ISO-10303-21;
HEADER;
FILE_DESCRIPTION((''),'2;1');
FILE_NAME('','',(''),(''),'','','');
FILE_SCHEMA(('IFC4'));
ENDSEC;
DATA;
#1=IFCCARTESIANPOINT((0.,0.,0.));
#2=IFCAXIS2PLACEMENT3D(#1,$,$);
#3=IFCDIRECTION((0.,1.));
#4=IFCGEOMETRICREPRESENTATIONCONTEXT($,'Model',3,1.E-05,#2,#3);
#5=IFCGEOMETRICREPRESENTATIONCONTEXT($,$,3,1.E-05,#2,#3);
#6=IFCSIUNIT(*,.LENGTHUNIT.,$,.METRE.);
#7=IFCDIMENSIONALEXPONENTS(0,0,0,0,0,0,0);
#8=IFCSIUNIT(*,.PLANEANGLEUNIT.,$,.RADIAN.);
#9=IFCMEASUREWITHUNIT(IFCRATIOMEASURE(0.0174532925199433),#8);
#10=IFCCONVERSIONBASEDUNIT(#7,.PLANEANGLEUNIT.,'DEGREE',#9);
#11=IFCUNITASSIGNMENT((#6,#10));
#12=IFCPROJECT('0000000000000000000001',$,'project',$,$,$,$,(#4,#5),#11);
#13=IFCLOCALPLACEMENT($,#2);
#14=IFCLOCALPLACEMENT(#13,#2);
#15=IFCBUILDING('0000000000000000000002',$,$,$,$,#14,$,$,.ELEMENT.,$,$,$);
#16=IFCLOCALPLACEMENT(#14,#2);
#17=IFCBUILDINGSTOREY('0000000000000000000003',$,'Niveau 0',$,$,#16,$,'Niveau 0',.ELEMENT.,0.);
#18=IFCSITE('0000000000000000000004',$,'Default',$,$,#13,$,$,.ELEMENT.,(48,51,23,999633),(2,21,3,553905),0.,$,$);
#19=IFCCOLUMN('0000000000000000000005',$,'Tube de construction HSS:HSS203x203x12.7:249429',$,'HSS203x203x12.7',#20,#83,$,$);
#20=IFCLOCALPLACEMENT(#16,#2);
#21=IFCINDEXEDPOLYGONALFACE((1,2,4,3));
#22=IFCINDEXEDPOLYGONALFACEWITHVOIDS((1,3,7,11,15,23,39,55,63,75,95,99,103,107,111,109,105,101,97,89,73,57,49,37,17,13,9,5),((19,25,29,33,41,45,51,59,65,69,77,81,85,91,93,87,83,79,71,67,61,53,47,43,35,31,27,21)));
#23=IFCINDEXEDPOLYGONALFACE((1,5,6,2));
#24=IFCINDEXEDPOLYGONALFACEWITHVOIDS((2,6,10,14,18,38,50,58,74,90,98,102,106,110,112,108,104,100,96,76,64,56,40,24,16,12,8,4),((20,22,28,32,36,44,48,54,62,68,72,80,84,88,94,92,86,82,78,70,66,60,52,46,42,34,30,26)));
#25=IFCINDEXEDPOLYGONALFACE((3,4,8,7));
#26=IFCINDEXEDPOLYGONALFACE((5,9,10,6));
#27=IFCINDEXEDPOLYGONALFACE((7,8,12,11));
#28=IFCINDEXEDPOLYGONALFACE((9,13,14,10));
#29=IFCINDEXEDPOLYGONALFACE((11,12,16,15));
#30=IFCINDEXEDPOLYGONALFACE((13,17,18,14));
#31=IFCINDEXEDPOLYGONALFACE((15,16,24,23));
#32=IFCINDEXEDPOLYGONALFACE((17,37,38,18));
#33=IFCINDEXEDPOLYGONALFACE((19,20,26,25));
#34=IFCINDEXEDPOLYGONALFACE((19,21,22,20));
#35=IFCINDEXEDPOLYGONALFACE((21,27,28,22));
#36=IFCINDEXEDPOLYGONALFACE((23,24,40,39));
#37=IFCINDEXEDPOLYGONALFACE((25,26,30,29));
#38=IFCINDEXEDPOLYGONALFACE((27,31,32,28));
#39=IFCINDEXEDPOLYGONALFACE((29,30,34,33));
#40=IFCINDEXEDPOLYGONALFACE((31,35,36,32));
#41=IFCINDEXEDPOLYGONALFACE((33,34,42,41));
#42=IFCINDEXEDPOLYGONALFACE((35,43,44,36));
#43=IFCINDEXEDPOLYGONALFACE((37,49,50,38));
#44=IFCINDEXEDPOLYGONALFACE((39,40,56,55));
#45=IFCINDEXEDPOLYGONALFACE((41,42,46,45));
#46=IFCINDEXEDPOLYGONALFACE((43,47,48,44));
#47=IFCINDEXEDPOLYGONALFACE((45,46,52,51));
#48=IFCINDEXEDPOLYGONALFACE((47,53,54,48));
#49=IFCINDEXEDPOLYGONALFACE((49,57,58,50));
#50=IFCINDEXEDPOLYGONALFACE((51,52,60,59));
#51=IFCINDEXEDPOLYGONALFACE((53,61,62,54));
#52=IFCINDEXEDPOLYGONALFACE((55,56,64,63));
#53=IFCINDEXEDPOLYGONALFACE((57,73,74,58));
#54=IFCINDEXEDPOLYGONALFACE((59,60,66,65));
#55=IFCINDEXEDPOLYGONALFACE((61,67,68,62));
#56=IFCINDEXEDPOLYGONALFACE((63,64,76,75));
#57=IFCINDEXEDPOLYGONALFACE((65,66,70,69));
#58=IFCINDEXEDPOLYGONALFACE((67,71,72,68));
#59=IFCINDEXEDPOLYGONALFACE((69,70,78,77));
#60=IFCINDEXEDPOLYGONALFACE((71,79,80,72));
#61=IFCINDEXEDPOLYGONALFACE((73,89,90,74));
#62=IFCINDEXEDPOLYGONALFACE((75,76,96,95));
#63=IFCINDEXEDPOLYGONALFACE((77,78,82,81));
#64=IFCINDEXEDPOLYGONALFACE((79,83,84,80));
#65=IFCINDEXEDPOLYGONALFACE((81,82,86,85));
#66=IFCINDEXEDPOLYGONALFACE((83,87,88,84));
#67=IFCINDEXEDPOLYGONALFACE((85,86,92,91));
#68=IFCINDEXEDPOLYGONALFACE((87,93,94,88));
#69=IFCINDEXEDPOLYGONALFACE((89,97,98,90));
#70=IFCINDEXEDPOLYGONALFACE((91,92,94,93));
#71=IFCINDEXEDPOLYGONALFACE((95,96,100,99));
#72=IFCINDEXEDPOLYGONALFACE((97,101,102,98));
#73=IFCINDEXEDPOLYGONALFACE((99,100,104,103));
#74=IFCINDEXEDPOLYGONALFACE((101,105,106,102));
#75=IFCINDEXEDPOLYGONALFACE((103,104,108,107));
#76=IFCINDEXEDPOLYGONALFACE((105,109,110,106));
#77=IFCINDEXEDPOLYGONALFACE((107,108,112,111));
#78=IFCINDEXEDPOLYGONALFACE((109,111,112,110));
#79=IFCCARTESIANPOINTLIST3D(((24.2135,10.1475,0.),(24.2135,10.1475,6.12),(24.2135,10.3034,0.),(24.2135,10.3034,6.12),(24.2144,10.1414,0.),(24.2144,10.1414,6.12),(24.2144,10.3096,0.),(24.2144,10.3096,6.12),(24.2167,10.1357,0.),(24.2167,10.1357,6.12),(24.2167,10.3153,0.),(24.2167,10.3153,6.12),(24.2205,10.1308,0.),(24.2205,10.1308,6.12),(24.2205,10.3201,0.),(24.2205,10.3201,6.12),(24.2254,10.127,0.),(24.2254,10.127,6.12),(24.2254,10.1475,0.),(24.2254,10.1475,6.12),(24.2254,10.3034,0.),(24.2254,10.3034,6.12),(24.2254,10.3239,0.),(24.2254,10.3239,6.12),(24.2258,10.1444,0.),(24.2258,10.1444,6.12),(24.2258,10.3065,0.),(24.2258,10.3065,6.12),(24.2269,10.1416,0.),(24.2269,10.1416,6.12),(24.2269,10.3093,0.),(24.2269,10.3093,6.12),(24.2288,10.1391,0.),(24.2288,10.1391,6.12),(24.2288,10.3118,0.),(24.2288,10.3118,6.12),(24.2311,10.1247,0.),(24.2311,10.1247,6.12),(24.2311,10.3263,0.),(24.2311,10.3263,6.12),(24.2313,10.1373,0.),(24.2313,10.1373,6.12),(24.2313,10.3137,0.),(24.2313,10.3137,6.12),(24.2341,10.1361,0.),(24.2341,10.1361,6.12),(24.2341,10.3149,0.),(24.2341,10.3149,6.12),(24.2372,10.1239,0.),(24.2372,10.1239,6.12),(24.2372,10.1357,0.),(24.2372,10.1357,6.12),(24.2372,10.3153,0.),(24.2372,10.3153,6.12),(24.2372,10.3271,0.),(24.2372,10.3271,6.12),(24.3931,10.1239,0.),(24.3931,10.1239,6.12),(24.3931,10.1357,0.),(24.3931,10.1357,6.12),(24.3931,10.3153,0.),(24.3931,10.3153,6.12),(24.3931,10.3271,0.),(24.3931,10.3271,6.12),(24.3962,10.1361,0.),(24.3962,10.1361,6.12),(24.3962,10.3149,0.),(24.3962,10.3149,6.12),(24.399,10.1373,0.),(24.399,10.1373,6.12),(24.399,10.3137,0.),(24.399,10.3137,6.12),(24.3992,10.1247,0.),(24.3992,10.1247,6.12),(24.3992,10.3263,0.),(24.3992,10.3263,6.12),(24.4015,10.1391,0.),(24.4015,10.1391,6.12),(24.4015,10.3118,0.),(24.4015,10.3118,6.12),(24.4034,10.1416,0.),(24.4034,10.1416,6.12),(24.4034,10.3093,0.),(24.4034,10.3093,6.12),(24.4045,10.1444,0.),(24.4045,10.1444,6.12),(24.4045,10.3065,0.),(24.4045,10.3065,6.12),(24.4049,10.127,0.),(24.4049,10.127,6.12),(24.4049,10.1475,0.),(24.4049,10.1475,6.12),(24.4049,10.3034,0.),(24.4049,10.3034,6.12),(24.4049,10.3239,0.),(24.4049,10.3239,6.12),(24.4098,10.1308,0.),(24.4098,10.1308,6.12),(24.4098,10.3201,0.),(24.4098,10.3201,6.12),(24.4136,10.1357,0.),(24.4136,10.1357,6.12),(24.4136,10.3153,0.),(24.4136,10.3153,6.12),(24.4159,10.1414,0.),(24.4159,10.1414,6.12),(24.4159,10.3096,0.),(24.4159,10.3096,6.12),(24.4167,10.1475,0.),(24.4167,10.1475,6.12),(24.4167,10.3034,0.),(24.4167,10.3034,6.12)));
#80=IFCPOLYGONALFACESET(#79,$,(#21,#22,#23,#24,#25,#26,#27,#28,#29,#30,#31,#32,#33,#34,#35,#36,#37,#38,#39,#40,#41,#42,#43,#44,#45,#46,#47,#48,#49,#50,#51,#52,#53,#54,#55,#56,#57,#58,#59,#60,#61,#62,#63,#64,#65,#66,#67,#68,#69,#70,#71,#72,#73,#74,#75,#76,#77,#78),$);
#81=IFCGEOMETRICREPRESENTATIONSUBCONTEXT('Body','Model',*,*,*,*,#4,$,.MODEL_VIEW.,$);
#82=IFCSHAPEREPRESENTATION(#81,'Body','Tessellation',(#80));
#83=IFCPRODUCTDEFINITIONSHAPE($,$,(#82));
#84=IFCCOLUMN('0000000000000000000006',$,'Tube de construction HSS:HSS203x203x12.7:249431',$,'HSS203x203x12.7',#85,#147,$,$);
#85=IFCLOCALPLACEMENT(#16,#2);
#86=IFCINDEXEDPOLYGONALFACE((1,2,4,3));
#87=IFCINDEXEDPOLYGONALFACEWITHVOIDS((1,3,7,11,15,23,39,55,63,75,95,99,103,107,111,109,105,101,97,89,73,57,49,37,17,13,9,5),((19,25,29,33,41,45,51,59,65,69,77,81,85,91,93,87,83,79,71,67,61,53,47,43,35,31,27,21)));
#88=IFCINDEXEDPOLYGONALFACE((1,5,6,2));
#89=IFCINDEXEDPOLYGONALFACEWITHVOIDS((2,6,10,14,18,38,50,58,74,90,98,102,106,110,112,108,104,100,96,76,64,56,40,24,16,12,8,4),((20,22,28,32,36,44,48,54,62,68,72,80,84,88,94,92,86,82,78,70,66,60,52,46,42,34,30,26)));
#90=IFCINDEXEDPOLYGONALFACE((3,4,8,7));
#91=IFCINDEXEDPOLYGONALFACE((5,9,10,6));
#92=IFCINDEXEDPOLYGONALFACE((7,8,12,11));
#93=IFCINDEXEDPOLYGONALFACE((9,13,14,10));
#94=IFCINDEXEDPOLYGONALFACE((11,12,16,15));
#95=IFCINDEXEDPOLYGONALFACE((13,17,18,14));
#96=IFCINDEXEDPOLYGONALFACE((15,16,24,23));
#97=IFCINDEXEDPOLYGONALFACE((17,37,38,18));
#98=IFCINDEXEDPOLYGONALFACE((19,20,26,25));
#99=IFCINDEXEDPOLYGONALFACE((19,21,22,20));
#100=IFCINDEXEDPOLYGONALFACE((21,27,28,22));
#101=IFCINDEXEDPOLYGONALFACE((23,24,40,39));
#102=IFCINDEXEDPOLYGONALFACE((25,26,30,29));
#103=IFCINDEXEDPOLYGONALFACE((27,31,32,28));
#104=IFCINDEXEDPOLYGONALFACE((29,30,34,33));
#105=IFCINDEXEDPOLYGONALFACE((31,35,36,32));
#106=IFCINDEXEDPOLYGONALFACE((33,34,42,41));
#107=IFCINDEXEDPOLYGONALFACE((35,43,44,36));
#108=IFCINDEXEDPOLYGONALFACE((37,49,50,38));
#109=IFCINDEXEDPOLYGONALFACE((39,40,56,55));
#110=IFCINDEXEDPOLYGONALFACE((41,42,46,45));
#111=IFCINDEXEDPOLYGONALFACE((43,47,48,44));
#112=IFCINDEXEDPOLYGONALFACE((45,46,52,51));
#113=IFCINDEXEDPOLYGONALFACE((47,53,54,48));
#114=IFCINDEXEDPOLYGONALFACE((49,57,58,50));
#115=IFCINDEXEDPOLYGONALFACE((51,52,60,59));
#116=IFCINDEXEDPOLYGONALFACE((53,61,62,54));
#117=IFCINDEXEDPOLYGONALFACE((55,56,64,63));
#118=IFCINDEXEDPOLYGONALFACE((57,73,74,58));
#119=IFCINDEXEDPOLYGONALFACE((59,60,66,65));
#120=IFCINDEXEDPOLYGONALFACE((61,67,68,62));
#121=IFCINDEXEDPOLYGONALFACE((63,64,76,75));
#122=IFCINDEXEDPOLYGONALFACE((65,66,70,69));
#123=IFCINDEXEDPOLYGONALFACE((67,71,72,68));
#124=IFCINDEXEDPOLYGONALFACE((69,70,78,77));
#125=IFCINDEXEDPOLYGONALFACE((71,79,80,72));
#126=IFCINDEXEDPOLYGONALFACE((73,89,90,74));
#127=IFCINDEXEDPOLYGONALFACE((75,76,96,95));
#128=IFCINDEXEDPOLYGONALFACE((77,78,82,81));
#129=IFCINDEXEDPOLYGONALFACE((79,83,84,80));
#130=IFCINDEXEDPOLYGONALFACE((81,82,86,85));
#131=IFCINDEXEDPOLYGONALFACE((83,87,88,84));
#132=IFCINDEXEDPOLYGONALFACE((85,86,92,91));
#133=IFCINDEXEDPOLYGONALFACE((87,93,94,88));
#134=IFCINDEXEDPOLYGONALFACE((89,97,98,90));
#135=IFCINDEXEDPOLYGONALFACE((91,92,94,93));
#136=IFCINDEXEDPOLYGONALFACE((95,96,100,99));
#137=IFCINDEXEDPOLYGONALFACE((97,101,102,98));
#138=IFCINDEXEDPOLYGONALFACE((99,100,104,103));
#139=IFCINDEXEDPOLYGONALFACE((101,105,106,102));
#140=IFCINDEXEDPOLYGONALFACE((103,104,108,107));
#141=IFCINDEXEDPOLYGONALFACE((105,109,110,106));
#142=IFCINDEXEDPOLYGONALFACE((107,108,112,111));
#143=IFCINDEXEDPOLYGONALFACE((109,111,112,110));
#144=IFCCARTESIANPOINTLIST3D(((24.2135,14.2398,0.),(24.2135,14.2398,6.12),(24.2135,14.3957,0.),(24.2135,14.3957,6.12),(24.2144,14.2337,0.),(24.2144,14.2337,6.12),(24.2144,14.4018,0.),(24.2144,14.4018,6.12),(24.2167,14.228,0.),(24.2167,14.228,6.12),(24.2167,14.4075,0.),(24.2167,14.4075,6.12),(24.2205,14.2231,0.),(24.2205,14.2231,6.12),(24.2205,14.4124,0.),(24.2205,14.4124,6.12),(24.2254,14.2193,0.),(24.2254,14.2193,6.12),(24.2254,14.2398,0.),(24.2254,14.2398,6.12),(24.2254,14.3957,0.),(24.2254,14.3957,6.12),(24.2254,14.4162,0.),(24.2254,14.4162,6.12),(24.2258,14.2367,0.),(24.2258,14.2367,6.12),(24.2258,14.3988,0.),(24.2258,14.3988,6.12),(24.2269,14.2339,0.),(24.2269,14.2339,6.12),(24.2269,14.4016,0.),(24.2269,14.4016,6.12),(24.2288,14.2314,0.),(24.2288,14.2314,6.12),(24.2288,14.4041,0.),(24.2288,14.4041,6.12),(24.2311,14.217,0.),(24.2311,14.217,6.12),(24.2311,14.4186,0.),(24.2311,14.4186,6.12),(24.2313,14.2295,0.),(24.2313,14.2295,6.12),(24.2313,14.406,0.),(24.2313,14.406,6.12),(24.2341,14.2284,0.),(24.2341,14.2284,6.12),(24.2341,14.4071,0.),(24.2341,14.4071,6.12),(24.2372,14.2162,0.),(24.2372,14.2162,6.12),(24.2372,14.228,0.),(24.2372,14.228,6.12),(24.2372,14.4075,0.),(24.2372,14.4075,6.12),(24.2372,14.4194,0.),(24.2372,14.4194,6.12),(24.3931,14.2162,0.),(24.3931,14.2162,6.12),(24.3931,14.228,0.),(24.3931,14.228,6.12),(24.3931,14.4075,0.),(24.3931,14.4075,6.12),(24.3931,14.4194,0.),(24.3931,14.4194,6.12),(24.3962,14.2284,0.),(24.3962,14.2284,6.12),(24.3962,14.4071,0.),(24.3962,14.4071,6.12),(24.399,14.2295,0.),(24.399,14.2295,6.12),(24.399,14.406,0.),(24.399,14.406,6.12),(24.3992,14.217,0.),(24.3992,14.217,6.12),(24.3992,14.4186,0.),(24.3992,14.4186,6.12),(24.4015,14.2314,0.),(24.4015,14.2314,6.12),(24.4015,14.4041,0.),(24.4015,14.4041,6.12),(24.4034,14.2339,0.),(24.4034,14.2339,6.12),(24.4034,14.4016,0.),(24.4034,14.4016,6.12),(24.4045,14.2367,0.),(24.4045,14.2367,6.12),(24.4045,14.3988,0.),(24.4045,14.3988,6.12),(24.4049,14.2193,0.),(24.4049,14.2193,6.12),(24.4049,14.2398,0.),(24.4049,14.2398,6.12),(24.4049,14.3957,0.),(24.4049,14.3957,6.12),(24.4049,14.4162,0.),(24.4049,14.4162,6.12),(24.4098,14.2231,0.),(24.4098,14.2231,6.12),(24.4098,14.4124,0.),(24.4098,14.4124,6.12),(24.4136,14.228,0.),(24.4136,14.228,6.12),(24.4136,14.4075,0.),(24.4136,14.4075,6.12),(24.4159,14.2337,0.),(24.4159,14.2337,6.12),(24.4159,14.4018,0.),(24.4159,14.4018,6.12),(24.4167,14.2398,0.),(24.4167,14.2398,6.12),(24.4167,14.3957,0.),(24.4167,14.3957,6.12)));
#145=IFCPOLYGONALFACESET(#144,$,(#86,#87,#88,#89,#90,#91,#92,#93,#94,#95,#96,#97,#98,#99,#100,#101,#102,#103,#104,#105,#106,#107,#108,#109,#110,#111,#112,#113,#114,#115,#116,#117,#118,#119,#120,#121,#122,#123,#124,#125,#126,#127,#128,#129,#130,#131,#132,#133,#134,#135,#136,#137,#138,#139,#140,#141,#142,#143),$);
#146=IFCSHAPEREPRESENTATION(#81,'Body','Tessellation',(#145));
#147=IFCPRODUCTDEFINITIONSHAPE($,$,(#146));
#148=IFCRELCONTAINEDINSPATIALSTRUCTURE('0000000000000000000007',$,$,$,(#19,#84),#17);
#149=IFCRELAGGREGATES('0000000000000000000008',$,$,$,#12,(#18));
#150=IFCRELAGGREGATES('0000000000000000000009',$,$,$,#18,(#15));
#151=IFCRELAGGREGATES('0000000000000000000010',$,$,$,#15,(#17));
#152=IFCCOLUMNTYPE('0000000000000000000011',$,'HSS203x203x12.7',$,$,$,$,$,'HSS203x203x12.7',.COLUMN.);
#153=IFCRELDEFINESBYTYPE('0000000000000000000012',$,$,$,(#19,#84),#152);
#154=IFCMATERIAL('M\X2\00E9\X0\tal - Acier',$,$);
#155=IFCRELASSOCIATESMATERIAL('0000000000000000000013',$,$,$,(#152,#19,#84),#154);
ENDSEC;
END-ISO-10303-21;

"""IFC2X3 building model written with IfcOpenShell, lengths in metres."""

from ifc_helpers import new_model, entity, si_unit, converted_unit, direction, frame, frame_2d, origin, place, context, subcontext, project, spatial, polyline, circle_curve, parameter, trimmed, segment, composite_curve, outline, extrude, source, transform, mapped, material, type_object, type_shapes, element, save


model = new_model("IFC2X3")

# Units and contexts
model_context = context("Model", 3, precision=1e-05, world=origin(), true_north=direction((0.0, 1.0)))
context_of_model = context(None, 3, precision=1e-05, world=origin(), true_north=direction((0.0, 1.0)))
body_context = subcontext(model_context, "Body", "Model", "MODEL_VIEW")
ifc_project = project(units=[si_unit("LENGTHUNIT", "METRE"), converted_unit("PLANEANGLEUNIT", "DEGREE", entity("IfcRatioMeasure", 0.0174532925199433), si_unit("PLANEANGLEUNIT", "RADIAN"), dimensions=[0, 0, 0, 0, 0, 0, 0])], contexts=[model_context, context_of_model])

# Site, building, storey
site_placement = place(None, origin())
site = spatial("IfcSite", under=ifc_project, at=site_placement, Name="Default", CompositionType="ELEMENT", RefLatitude=(48, 51, 23, 999633), RefLongitude=(2, 21, 3, 553905), RefElevation=0.0)
building_placement = place(site_placement, origin())
building = spatial("IfcBuilding", under=site, at=building_placement, CompositionType="ELEMENT")
storey_placement = place(building_placement, origin())
storey = spatial("IfcBuildingStorey", under=building, at=storey_placement, Name="Niveau 0", LongName="Niveau 0", CompositionType="ELEMENT", Elevation=0.0)

# Columns
ifc_material_1 = material(Name="Métal - Acier")
column_type = type_object("IfcColumnType", Name="HSS203x203x12.7", ElementType="HSS203x203x12.7", PredefinedType="COLUMN", material=ifc_material_1)
shared_shape = source(origin(), body_context, "Body", "SweptSolid", [
    extrude(outline(composite_curve([segment(polyline([(-0.078, -0.1016), (0.078, -0.1016)]), True, "CONTINUOUS"), segment(trimmed(circle_curve(frame_2d((0.078, -0.078), x_axis=(-1.0, 0.0)), 0.0236), [parameter(90.0)], [parameter(180.0)], True, "PARAMETER"), True, "CONTINUOUS"), segment(polyline([(0.1016, -0.078), (0.1016, 0.078)]), True, "CONTINUOUS"), segment(trimmed(circle_curve(frame_2d((0.078, 0.078), x_axis=(-1.0, 0.0)), 0.0236), [parameter(180.0)], [parameter(270.0)], True, "PARAMETER"), True, "CONTINUOUS"), segment(polyline([(0.078, 0.1016), (-0.078, 0.1016)]), True, "CONTINUOUS"), segment(trimmed(circle_curve(frame_2d((-0.078, 0.078), x_axis=(-1.0, 0.0)), 0.0236), [parameter(270.0)], [parameter(360.0)], True, "PARAMETER"), True, "CONTINUOUS"), segment(polyline([(-0.1016, 0.078), (-0.1016, -0.078)]), True, "CONTINUOUS"), segment(trimmed(circle_curve(frame_2d((-0.078, -0.078), x_axis=(-1.0, 0.0)), 0.0236), [parameter(360.0)], [parameter(90.0)], True, "PARAMETER"), True, "CONTINUOUS")], self_intersect=False), holes=[composite_curve([segment(trimmed(circle_curve(frame_2d((-0.078, -0.078), x_axis=(-1.0, 0.0)), 0.0118), [parameter(0.0)], [parameter(90.0)], True, "PARAMETER"), False, "CONTINUOUS"), segment(polyline([(-0.0898, -0.078), (-0.0898, 0.078)]), True, "CONTINUOUS"), segment(trimmed(circle_curve(frame_2d((-0.078, 0.078), x_axis=(-1.0, 0.0)), 0.0118), [parameter(270.0)], [parameter(360.0)], True, "PARAMETER"), False, "CONTINUOUS"), segment(polyline([(-0.078, 0.0898), (0.078, 0.0898)]), True, "CONTINUOUS"), segment(trimmed(circle_curve(frame_2d((0.078, 0.078), x_axis=(-1.0, 0.0)), 0.0118), [parameter(180.0)], [parameter(270.0)], True, "PARAMETER"), False, "CONTINUOUS"), segment(polyline([(0.0898, 0.078), (0.0898, -0.078)]), True, "CONTINUOUS"), segment(trimmed(circle_curve(frame_2d((0.078, -0.078), x_axis=(-1.0, 0.0)), 0.0118), [parameter(90.0)], [parameter(180.0)], True, "PARAMETER"), False, "CONTINUOUS"), segment(polyline([(0.078, -0.0898), (-0.078, -0.0898)]), True, "CONTINUOUS")], self_intersect=False)]), frame((0.0, 0.0, 0.0), z_axis=(0.0, 0.0, 1.0), x_axis=(-1.0, 0.0, 0.0)), (0.0, 0.0, 1.0), 6.12),
])
type_shapes(column_type, [shared_shape])
for number, where, name in (
    (1, (24.3151, 10.2255, 0.0), "Tube de construction HSS:HSS203x203x12.7:249429"),
    (2, (24.3151, 14.3178, 0.0), "Tube de construction HSS:HSS203x203x12.7:249431"),
):
    element("IfcColumn", number, at=place(storey_placement, frame(where)), inside=storey, type_object=column_type, material=ifc_material_1, Name=name, ObjectType="HSS203x203x12.7", context=body_context, shape_type="MappedRepresentation", body=[
        mapped(shared_shape, transform((0.0, 0.0, 0.0), scale=1.0)),
    ])

save(model, "model.ifc")
